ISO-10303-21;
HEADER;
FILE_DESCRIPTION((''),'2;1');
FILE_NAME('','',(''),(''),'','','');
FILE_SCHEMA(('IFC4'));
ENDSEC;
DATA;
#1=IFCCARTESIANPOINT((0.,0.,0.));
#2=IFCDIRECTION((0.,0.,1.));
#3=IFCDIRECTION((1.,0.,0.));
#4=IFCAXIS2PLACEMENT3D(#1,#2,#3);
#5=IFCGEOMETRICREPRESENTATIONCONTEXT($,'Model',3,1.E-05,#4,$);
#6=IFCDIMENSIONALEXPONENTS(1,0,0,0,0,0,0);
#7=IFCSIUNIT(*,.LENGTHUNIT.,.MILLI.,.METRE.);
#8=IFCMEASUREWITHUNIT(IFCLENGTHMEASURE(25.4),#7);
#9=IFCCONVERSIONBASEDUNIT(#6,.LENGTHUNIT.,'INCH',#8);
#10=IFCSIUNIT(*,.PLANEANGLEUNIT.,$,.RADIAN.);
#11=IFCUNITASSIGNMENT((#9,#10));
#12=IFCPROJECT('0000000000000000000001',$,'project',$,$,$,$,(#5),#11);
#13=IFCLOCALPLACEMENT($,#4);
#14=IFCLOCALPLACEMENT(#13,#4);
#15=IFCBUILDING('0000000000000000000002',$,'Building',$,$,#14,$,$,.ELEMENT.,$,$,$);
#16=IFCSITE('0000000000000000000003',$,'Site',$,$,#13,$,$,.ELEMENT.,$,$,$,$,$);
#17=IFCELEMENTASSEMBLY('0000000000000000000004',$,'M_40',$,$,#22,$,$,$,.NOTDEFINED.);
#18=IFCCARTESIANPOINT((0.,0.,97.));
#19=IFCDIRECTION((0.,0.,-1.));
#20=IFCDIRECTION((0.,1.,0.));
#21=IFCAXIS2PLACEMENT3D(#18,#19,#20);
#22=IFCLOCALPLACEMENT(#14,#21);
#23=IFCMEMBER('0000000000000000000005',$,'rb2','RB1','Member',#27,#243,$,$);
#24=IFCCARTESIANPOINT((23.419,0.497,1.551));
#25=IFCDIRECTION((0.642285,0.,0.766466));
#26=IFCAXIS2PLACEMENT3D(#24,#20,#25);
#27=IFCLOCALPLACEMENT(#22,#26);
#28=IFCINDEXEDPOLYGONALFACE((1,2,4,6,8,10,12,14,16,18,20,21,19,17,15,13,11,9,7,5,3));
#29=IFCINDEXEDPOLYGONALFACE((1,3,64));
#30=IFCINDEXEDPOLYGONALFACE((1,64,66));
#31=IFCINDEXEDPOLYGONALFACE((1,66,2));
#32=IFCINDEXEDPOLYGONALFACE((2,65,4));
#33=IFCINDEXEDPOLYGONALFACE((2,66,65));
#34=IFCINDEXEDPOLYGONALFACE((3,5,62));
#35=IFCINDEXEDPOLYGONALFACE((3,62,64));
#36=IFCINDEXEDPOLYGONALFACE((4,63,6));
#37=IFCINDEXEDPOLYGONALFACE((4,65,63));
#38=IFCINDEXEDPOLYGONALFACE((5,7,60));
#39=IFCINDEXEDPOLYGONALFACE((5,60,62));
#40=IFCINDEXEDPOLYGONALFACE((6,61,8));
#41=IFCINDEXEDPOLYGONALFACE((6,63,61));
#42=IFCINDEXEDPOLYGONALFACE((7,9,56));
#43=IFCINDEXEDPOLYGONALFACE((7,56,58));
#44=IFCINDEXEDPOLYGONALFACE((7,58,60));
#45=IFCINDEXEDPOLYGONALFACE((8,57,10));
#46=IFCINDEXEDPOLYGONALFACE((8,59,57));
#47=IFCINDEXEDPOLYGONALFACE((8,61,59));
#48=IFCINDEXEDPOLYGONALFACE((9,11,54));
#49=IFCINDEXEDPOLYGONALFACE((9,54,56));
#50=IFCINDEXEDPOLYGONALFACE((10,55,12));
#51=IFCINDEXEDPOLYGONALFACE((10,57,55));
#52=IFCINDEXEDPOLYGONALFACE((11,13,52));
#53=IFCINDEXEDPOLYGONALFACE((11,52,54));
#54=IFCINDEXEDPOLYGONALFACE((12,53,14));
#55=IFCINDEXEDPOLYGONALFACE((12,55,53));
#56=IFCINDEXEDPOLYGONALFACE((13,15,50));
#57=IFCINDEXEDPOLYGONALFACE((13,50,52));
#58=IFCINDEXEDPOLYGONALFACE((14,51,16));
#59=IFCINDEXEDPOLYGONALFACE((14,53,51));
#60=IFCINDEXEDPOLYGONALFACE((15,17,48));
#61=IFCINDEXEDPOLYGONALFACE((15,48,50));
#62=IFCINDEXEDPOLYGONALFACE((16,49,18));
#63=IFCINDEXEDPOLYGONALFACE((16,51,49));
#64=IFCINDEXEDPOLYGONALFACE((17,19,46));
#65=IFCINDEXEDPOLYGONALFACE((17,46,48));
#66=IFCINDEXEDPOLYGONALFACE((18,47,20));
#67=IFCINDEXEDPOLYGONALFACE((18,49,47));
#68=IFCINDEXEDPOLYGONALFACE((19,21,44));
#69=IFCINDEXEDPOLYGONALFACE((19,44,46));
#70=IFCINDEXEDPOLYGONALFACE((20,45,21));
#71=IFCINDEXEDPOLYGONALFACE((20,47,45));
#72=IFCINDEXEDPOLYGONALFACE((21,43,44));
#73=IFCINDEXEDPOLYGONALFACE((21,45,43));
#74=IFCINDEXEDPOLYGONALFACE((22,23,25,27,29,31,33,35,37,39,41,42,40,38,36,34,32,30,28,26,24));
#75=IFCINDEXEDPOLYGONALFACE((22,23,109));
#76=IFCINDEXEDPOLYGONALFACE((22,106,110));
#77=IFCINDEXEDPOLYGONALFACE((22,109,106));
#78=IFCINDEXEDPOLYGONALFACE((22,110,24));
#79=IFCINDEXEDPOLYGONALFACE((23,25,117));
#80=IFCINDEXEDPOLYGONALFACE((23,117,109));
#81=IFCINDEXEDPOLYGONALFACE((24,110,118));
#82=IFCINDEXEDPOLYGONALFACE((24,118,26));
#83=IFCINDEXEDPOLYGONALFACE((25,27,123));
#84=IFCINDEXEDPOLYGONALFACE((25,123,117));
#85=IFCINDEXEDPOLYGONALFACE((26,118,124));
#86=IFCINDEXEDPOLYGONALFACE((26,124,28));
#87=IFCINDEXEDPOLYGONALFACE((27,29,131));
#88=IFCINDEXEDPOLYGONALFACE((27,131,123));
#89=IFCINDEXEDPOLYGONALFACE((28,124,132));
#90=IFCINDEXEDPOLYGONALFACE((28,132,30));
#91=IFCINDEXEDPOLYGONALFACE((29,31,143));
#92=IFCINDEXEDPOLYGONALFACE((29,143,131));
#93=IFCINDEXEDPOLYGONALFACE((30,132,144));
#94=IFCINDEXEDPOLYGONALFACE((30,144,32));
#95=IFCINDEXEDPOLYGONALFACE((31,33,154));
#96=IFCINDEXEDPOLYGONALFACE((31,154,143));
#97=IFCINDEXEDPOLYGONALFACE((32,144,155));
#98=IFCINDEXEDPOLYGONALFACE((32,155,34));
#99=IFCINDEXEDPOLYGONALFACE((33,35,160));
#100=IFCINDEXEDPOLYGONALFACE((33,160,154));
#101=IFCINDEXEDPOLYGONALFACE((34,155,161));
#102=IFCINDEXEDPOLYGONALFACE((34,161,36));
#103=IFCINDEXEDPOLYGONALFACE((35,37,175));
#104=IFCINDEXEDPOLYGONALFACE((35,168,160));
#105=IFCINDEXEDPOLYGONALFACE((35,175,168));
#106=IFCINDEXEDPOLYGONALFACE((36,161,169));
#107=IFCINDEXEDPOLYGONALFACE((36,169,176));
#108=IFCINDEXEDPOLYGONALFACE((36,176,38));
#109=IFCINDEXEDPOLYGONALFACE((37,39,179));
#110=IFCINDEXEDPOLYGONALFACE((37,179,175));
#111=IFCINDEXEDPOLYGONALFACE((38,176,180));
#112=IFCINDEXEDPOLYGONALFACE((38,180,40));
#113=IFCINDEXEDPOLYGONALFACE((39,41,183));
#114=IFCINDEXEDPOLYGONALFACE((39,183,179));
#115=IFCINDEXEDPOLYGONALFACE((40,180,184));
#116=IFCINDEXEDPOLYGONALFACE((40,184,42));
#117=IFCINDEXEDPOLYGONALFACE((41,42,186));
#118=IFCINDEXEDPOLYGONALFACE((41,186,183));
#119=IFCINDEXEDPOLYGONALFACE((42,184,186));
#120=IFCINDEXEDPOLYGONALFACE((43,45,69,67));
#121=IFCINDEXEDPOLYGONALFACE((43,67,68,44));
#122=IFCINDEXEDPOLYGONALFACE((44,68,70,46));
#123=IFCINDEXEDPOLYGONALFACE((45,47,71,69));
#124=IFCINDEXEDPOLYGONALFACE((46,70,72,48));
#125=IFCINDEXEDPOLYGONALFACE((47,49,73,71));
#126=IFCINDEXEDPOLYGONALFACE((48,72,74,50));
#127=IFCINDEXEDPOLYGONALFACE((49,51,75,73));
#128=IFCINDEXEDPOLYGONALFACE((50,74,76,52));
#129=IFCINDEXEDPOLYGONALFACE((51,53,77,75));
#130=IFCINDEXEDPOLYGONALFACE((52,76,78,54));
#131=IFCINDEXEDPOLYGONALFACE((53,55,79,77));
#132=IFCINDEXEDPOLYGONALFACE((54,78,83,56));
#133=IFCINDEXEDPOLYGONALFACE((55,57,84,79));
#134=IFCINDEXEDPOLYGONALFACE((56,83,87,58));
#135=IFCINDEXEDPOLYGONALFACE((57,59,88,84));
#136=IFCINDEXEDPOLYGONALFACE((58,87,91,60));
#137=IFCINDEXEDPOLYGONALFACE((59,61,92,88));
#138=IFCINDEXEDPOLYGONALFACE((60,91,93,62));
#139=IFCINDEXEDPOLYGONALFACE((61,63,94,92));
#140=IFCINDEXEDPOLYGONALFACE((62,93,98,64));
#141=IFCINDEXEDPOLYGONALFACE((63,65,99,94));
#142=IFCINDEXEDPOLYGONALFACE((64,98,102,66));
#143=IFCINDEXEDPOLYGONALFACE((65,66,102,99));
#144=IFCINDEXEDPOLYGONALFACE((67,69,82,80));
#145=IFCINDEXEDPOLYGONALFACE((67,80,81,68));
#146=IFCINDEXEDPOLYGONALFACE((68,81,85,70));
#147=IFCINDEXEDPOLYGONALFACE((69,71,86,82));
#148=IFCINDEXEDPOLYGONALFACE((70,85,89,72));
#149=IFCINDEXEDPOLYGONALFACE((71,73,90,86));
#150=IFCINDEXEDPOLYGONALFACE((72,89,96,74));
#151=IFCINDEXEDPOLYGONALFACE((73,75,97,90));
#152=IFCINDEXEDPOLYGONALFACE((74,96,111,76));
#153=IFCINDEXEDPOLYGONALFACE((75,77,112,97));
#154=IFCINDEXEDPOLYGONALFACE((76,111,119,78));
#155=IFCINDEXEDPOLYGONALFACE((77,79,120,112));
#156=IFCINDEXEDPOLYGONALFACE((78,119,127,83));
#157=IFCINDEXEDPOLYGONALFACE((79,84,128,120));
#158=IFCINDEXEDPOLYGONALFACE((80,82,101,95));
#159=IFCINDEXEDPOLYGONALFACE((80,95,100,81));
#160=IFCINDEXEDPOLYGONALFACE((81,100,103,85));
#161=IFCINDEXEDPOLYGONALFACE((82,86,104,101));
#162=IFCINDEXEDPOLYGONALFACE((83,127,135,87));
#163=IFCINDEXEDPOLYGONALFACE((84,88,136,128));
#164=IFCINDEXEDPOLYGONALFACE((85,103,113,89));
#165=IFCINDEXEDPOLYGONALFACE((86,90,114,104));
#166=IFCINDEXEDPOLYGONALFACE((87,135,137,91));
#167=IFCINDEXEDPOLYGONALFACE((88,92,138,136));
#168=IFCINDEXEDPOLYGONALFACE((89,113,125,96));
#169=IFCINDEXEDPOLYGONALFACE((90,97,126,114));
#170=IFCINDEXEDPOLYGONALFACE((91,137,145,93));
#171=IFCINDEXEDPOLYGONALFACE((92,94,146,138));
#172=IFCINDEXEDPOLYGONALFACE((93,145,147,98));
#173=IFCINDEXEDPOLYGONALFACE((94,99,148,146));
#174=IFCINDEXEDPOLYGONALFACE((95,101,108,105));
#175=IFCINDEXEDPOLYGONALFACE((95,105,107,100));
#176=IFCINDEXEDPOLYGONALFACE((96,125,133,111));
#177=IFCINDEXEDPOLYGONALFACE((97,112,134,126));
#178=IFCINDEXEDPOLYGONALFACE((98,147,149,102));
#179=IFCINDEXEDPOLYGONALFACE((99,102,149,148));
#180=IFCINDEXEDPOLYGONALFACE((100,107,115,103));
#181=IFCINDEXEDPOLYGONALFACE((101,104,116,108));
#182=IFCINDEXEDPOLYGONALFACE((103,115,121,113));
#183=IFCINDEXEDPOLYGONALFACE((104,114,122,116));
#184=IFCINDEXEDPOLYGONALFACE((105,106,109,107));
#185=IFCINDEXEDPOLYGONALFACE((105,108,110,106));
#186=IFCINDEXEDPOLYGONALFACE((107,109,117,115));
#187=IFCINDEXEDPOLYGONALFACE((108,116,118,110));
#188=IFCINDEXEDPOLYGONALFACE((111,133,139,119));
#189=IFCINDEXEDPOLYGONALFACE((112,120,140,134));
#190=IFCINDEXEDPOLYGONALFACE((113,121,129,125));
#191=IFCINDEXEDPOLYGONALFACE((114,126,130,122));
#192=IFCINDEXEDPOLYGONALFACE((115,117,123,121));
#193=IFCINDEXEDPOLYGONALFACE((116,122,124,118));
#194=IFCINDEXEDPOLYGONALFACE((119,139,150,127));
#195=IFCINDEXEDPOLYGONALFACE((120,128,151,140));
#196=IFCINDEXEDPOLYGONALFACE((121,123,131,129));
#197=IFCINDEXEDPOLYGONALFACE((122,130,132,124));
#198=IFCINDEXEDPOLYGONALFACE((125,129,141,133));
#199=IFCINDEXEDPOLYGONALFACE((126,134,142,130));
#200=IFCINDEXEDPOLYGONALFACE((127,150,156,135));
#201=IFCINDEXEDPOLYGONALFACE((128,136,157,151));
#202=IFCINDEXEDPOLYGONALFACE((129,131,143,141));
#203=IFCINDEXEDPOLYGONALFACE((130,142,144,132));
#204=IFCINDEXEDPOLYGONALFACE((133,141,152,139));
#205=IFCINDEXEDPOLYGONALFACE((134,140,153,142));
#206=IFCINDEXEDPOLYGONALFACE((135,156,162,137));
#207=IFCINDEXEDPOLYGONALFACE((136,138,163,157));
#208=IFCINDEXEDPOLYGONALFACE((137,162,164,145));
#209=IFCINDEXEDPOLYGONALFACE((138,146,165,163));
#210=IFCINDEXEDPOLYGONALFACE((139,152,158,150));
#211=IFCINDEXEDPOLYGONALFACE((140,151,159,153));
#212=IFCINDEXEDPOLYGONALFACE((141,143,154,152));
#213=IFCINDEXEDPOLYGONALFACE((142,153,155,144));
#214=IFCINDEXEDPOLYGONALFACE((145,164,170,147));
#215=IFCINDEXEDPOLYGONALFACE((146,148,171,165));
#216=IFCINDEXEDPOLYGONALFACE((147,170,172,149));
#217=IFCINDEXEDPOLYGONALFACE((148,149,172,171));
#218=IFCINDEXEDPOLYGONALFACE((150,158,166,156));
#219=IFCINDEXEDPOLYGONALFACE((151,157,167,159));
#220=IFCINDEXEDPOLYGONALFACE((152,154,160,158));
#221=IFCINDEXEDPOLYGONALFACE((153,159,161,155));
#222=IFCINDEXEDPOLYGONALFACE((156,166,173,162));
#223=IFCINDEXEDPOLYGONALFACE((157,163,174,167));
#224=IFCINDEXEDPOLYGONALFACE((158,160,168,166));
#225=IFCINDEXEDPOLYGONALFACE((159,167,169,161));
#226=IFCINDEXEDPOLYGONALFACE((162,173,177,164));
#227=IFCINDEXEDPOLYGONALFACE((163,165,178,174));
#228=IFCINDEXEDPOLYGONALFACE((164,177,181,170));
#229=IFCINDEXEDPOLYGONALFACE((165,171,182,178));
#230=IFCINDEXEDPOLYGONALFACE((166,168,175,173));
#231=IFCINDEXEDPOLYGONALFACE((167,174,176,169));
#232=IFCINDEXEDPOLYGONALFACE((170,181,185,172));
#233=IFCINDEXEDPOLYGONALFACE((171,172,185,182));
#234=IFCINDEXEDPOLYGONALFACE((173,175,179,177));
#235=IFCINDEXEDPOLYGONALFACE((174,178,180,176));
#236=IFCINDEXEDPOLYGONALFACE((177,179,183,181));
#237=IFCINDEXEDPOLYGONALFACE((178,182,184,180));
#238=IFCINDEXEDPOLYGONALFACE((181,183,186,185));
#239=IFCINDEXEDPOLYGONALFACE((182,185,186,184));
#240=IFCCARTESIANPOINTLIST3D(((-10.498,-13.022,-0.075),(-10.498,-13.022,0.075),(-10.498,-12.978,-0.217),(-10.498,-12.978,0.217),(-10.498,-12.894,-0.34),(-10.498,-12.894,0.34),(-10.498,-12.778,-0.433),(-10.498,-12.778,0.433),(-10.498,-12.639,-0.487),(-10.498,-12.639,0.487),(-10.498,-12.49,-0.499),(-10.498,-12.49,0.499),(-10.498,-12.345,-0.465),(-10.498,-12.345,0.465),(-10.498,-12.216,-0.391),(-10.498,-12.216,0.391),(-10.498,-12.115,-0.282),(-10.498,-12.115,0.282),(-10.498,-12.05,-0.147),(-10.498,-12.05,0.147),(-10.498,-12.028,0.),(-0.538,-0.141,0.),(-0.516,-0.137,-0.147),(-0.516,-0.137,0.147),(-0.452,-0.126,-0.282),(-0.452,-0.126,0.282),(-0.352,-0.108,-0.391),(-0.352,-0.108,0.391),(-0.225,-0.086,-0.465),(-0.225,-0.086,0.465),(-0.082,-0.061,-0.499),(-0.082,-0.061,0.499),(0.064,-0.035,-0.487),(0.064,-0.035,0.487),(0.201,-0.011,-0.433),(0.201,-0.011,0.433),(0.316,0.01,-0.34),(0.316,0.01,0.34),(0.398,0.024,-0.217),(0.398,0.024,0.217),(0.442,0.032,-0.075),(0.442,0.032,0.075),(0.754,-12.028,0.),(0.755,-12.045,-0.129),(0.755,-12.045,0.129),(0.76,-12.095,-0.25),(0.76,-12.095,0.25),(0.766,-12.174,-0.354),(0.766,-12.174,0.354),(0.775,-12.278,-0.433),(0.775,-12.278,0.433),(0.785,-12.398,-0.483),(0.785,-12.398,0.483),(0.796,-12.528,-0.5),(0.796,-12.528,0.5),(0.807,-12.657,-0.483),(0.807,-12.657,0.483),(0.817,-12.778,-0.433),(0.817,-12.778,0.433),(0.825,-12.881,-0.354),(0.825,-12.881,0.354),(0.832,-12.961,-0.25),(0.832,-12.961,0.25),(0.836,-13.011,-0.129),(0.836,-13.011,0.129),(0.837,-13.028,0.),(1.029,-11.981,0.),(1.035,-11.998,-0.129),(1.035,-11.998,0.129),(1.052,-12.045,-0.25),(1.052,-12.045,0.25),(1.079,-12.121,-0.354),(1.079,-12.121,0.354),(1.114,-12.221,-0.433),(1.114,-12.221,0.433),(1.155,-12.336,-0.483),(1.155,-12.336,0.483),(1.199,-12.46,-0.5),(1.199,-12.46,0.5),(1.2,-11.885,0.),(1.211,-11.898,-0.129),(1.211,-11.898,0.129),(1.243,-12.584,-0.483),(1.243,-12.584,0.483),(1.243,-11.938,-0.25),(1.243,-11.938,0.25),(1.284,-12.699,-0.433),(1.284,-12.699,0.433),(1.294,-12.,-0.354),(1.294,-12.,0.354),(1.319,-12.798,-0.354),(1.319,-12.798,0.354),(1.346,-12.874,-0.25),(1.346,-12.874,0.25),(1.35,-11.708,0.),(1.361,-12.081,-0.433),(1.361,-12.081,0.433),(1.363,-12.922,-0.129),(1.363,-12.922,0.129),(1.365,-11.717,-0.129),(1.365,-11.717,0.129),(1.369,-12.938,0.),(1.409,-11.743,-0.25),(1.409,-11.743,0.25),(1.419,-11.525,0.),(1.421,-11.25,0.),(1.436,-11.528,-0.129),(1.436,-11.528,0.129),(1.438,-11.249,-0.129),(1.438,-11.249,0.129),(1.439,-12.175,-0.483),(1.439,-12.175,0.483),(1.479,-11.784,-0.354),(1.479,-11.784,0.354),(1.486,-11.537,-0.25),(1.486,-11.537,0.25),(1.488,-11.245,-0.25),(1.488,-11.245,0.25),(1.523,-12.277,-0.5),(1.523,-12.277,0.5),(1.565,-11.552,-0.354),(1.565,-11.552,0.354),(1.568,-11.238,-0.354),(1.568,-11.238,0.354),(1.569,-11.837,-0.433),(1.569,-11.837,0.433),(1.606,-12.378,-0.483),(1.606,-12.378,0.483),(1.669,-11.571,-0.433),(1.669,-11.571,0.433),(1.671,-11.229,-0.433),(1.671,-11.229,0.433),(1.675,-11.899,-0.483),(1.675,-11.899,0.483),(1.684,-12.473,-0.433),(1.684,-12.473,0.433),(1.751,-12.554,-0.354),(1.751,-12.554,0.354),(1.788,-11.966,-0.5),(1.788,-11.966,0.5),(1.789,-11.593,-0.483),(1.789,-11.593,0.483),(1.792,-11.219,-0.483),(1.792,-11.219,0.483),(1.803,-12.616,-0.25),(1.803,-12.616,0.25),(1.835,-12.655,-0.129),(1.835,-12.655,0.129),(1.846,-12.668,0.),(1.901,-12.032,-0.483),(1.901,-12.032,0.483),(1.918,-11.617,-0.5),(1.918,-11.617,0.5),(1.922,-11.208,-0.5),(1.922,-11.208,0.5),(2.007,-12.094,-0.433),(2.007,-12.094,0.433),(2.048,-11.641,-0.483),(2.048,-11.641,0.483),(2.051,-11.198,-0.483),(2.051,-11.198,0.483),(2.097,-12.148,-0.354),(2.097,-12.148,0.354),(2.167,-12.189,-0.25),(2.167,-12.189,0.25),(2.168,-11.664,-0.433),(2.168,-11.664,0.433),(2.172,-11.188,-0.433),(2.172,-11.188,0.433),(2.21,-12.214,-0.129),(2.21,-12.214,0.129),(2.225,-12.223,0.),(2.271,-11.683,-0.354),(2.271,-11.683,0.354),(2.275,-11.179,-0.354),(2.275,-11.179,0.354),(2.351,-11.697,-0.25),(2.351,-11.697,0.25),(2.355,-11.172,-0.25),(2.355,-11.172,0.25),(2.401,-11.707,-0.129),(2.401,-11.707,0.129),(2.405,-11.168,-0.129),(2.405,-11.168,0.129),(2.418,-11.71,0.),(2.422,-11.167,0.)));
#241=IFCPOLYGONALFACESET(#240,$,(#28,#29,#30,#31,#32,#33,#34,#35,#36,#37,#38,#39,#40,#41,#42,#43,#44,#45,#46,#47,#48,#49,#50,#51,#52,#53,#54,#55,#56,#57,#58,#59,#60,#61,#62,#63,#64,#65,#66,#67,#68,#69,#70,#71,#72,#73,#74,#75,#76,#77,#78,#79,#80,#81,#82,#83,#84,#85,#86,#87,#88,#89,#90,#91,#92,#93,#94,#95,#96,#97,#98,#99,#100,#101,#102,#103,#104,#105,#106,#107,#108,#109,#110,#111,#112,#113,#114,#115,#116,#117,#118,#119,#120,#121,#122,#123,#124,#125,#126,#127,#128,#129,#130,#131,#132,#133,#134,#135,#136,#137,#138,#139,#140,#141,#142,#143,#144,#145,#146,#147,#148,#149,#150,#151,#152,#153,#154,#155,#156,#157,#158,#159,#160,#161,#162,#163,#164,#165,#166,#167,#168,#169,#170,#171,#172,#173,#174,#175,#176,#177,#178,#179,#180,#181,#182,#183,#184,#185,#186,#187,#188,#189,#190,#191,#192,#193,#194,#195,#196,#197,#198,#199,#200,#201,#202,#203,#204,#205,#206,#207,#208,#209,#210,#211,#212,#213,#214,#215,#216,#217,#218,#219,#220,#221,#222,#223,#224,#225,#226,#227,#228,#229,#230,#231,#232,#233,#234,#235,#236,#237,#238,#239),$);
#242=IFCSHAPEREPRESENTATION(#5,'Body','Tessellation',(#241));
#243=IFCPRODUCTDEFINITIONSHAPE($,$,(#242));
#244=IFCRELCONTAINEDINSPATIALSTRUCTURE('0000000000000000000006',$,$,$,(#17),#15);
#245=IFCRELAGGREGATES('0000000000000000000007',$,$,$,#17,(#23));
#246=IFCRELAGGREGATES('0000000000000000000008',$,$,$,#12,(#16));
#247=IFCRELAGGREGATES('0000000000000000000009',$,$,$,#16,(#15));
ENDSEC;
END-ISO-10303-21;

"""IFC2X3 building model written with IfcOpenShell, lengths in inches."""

from ifc_helpers import new_model, entity, si_unit, converted_unit, frame, origin_with_axes, place, context, project, spatial, element, aggregate, save


model = new_model("IFC2X3")

# Units and contexts
model_context = context("Model", 3, precision=1e-05, world=origin_with_axes())
ifc_project = project(units=[converted_unit("LENGTHUNIT", "INCH", entity("IfcLengthMeasure", 25.4), si_unit("LENGTHUNIT", "METRE", prefix="MILLI"), dimensions=[1, 0, 0, 0, 0, 0, 0]), si_unit("PLANEANGLEUNIT", "RADIAN")], contexts=[model_context])

# Site, building
site_placement = place(None, origin_with_axes())
site = spatial("IfcSite", under=ifc_project, at=site_placement, Name="Site", CompositionType="ELEMENT")
building_placement = place(site_placement, origin_with_axes())
building = spatial("IfcBuilding", under=site, at=building_placement, Name="Building", CompositionType="ELEMENT")

# Element assembly, member
assembly_1_placement = place(building_placement, frame((0.0, 0.0, 97.0), z_axis=(0.0, 0.0, -1.0), x_axis=(0.0, 1.0, 0.0)))
assembly_1 = element("IfcElementAssembly", 1, at=assembly_1_placement, inside=building, Name="M_40", PredefinedType="NOTDEFINED")
member_1_placement = place(assembly_1_placement, frame((23.419, 0.497, 1.551), z_axis=(0.0, 1.0, 0.0), x_axis=(0.642285, 0.0, 0.766466)))
cartesian_point_1 = entity("IfcCartesianPoint", [0.0, 0.0, 0.0])
ifc_direction_1 = entity("IfcDirection", [0.0, 0.0, 1.0])
member_1 = element("IfcMember", 2, at=member_1_placement, Name="rb2", Description="RB1", ObjectType="Member", context=model_context, shape_type="SweptSolid", body=[
    entity("IfcSurfaceCurveSweptAreaSolid", entity("IfcCircleProfileDef", "AREA", None, entity("IfcAxis2Placement2D", entity("IfcCartesianPoint", [0.0, 0.0]), entity("IfcDirection", [1.0, 0.0])), 0.5), entity("IfcAxis2Placement3D", cartesian_point_1, ifc_direction_1, entity("IfcDirection", [1.0, 0.0, 0.0])), entity("IfcPolyline", [entity("IfcCartesianPoint", [-0.045, -0.054]), entity("IfcCartesianPoint", [1.921, -11.208]), entity("IfcCartesianPoint", [1.918, -11.617]), entity("IfcCartesianPoint", [1.788, -11.966]), entity("IfcCartesianPoint", [1.523, -12.277]), entity("IfcCartesianPoint", [1.199, -12.46]), entity("IfcCartesianPoint", [0.796, -12.528]), entity("IfcCartesianPoint", [-10.498, -12.528])]), 0.0, 1.0, entity("IfcPlane", entity("IfcAxis2Placement3D", cartesian_point_1, entity("IfcDirection", [0.0, 1.0, 0.0]), ifc_direction_1))),
])
aggregate(assembly_1, [member_1])

save(model, "model.ifc")
